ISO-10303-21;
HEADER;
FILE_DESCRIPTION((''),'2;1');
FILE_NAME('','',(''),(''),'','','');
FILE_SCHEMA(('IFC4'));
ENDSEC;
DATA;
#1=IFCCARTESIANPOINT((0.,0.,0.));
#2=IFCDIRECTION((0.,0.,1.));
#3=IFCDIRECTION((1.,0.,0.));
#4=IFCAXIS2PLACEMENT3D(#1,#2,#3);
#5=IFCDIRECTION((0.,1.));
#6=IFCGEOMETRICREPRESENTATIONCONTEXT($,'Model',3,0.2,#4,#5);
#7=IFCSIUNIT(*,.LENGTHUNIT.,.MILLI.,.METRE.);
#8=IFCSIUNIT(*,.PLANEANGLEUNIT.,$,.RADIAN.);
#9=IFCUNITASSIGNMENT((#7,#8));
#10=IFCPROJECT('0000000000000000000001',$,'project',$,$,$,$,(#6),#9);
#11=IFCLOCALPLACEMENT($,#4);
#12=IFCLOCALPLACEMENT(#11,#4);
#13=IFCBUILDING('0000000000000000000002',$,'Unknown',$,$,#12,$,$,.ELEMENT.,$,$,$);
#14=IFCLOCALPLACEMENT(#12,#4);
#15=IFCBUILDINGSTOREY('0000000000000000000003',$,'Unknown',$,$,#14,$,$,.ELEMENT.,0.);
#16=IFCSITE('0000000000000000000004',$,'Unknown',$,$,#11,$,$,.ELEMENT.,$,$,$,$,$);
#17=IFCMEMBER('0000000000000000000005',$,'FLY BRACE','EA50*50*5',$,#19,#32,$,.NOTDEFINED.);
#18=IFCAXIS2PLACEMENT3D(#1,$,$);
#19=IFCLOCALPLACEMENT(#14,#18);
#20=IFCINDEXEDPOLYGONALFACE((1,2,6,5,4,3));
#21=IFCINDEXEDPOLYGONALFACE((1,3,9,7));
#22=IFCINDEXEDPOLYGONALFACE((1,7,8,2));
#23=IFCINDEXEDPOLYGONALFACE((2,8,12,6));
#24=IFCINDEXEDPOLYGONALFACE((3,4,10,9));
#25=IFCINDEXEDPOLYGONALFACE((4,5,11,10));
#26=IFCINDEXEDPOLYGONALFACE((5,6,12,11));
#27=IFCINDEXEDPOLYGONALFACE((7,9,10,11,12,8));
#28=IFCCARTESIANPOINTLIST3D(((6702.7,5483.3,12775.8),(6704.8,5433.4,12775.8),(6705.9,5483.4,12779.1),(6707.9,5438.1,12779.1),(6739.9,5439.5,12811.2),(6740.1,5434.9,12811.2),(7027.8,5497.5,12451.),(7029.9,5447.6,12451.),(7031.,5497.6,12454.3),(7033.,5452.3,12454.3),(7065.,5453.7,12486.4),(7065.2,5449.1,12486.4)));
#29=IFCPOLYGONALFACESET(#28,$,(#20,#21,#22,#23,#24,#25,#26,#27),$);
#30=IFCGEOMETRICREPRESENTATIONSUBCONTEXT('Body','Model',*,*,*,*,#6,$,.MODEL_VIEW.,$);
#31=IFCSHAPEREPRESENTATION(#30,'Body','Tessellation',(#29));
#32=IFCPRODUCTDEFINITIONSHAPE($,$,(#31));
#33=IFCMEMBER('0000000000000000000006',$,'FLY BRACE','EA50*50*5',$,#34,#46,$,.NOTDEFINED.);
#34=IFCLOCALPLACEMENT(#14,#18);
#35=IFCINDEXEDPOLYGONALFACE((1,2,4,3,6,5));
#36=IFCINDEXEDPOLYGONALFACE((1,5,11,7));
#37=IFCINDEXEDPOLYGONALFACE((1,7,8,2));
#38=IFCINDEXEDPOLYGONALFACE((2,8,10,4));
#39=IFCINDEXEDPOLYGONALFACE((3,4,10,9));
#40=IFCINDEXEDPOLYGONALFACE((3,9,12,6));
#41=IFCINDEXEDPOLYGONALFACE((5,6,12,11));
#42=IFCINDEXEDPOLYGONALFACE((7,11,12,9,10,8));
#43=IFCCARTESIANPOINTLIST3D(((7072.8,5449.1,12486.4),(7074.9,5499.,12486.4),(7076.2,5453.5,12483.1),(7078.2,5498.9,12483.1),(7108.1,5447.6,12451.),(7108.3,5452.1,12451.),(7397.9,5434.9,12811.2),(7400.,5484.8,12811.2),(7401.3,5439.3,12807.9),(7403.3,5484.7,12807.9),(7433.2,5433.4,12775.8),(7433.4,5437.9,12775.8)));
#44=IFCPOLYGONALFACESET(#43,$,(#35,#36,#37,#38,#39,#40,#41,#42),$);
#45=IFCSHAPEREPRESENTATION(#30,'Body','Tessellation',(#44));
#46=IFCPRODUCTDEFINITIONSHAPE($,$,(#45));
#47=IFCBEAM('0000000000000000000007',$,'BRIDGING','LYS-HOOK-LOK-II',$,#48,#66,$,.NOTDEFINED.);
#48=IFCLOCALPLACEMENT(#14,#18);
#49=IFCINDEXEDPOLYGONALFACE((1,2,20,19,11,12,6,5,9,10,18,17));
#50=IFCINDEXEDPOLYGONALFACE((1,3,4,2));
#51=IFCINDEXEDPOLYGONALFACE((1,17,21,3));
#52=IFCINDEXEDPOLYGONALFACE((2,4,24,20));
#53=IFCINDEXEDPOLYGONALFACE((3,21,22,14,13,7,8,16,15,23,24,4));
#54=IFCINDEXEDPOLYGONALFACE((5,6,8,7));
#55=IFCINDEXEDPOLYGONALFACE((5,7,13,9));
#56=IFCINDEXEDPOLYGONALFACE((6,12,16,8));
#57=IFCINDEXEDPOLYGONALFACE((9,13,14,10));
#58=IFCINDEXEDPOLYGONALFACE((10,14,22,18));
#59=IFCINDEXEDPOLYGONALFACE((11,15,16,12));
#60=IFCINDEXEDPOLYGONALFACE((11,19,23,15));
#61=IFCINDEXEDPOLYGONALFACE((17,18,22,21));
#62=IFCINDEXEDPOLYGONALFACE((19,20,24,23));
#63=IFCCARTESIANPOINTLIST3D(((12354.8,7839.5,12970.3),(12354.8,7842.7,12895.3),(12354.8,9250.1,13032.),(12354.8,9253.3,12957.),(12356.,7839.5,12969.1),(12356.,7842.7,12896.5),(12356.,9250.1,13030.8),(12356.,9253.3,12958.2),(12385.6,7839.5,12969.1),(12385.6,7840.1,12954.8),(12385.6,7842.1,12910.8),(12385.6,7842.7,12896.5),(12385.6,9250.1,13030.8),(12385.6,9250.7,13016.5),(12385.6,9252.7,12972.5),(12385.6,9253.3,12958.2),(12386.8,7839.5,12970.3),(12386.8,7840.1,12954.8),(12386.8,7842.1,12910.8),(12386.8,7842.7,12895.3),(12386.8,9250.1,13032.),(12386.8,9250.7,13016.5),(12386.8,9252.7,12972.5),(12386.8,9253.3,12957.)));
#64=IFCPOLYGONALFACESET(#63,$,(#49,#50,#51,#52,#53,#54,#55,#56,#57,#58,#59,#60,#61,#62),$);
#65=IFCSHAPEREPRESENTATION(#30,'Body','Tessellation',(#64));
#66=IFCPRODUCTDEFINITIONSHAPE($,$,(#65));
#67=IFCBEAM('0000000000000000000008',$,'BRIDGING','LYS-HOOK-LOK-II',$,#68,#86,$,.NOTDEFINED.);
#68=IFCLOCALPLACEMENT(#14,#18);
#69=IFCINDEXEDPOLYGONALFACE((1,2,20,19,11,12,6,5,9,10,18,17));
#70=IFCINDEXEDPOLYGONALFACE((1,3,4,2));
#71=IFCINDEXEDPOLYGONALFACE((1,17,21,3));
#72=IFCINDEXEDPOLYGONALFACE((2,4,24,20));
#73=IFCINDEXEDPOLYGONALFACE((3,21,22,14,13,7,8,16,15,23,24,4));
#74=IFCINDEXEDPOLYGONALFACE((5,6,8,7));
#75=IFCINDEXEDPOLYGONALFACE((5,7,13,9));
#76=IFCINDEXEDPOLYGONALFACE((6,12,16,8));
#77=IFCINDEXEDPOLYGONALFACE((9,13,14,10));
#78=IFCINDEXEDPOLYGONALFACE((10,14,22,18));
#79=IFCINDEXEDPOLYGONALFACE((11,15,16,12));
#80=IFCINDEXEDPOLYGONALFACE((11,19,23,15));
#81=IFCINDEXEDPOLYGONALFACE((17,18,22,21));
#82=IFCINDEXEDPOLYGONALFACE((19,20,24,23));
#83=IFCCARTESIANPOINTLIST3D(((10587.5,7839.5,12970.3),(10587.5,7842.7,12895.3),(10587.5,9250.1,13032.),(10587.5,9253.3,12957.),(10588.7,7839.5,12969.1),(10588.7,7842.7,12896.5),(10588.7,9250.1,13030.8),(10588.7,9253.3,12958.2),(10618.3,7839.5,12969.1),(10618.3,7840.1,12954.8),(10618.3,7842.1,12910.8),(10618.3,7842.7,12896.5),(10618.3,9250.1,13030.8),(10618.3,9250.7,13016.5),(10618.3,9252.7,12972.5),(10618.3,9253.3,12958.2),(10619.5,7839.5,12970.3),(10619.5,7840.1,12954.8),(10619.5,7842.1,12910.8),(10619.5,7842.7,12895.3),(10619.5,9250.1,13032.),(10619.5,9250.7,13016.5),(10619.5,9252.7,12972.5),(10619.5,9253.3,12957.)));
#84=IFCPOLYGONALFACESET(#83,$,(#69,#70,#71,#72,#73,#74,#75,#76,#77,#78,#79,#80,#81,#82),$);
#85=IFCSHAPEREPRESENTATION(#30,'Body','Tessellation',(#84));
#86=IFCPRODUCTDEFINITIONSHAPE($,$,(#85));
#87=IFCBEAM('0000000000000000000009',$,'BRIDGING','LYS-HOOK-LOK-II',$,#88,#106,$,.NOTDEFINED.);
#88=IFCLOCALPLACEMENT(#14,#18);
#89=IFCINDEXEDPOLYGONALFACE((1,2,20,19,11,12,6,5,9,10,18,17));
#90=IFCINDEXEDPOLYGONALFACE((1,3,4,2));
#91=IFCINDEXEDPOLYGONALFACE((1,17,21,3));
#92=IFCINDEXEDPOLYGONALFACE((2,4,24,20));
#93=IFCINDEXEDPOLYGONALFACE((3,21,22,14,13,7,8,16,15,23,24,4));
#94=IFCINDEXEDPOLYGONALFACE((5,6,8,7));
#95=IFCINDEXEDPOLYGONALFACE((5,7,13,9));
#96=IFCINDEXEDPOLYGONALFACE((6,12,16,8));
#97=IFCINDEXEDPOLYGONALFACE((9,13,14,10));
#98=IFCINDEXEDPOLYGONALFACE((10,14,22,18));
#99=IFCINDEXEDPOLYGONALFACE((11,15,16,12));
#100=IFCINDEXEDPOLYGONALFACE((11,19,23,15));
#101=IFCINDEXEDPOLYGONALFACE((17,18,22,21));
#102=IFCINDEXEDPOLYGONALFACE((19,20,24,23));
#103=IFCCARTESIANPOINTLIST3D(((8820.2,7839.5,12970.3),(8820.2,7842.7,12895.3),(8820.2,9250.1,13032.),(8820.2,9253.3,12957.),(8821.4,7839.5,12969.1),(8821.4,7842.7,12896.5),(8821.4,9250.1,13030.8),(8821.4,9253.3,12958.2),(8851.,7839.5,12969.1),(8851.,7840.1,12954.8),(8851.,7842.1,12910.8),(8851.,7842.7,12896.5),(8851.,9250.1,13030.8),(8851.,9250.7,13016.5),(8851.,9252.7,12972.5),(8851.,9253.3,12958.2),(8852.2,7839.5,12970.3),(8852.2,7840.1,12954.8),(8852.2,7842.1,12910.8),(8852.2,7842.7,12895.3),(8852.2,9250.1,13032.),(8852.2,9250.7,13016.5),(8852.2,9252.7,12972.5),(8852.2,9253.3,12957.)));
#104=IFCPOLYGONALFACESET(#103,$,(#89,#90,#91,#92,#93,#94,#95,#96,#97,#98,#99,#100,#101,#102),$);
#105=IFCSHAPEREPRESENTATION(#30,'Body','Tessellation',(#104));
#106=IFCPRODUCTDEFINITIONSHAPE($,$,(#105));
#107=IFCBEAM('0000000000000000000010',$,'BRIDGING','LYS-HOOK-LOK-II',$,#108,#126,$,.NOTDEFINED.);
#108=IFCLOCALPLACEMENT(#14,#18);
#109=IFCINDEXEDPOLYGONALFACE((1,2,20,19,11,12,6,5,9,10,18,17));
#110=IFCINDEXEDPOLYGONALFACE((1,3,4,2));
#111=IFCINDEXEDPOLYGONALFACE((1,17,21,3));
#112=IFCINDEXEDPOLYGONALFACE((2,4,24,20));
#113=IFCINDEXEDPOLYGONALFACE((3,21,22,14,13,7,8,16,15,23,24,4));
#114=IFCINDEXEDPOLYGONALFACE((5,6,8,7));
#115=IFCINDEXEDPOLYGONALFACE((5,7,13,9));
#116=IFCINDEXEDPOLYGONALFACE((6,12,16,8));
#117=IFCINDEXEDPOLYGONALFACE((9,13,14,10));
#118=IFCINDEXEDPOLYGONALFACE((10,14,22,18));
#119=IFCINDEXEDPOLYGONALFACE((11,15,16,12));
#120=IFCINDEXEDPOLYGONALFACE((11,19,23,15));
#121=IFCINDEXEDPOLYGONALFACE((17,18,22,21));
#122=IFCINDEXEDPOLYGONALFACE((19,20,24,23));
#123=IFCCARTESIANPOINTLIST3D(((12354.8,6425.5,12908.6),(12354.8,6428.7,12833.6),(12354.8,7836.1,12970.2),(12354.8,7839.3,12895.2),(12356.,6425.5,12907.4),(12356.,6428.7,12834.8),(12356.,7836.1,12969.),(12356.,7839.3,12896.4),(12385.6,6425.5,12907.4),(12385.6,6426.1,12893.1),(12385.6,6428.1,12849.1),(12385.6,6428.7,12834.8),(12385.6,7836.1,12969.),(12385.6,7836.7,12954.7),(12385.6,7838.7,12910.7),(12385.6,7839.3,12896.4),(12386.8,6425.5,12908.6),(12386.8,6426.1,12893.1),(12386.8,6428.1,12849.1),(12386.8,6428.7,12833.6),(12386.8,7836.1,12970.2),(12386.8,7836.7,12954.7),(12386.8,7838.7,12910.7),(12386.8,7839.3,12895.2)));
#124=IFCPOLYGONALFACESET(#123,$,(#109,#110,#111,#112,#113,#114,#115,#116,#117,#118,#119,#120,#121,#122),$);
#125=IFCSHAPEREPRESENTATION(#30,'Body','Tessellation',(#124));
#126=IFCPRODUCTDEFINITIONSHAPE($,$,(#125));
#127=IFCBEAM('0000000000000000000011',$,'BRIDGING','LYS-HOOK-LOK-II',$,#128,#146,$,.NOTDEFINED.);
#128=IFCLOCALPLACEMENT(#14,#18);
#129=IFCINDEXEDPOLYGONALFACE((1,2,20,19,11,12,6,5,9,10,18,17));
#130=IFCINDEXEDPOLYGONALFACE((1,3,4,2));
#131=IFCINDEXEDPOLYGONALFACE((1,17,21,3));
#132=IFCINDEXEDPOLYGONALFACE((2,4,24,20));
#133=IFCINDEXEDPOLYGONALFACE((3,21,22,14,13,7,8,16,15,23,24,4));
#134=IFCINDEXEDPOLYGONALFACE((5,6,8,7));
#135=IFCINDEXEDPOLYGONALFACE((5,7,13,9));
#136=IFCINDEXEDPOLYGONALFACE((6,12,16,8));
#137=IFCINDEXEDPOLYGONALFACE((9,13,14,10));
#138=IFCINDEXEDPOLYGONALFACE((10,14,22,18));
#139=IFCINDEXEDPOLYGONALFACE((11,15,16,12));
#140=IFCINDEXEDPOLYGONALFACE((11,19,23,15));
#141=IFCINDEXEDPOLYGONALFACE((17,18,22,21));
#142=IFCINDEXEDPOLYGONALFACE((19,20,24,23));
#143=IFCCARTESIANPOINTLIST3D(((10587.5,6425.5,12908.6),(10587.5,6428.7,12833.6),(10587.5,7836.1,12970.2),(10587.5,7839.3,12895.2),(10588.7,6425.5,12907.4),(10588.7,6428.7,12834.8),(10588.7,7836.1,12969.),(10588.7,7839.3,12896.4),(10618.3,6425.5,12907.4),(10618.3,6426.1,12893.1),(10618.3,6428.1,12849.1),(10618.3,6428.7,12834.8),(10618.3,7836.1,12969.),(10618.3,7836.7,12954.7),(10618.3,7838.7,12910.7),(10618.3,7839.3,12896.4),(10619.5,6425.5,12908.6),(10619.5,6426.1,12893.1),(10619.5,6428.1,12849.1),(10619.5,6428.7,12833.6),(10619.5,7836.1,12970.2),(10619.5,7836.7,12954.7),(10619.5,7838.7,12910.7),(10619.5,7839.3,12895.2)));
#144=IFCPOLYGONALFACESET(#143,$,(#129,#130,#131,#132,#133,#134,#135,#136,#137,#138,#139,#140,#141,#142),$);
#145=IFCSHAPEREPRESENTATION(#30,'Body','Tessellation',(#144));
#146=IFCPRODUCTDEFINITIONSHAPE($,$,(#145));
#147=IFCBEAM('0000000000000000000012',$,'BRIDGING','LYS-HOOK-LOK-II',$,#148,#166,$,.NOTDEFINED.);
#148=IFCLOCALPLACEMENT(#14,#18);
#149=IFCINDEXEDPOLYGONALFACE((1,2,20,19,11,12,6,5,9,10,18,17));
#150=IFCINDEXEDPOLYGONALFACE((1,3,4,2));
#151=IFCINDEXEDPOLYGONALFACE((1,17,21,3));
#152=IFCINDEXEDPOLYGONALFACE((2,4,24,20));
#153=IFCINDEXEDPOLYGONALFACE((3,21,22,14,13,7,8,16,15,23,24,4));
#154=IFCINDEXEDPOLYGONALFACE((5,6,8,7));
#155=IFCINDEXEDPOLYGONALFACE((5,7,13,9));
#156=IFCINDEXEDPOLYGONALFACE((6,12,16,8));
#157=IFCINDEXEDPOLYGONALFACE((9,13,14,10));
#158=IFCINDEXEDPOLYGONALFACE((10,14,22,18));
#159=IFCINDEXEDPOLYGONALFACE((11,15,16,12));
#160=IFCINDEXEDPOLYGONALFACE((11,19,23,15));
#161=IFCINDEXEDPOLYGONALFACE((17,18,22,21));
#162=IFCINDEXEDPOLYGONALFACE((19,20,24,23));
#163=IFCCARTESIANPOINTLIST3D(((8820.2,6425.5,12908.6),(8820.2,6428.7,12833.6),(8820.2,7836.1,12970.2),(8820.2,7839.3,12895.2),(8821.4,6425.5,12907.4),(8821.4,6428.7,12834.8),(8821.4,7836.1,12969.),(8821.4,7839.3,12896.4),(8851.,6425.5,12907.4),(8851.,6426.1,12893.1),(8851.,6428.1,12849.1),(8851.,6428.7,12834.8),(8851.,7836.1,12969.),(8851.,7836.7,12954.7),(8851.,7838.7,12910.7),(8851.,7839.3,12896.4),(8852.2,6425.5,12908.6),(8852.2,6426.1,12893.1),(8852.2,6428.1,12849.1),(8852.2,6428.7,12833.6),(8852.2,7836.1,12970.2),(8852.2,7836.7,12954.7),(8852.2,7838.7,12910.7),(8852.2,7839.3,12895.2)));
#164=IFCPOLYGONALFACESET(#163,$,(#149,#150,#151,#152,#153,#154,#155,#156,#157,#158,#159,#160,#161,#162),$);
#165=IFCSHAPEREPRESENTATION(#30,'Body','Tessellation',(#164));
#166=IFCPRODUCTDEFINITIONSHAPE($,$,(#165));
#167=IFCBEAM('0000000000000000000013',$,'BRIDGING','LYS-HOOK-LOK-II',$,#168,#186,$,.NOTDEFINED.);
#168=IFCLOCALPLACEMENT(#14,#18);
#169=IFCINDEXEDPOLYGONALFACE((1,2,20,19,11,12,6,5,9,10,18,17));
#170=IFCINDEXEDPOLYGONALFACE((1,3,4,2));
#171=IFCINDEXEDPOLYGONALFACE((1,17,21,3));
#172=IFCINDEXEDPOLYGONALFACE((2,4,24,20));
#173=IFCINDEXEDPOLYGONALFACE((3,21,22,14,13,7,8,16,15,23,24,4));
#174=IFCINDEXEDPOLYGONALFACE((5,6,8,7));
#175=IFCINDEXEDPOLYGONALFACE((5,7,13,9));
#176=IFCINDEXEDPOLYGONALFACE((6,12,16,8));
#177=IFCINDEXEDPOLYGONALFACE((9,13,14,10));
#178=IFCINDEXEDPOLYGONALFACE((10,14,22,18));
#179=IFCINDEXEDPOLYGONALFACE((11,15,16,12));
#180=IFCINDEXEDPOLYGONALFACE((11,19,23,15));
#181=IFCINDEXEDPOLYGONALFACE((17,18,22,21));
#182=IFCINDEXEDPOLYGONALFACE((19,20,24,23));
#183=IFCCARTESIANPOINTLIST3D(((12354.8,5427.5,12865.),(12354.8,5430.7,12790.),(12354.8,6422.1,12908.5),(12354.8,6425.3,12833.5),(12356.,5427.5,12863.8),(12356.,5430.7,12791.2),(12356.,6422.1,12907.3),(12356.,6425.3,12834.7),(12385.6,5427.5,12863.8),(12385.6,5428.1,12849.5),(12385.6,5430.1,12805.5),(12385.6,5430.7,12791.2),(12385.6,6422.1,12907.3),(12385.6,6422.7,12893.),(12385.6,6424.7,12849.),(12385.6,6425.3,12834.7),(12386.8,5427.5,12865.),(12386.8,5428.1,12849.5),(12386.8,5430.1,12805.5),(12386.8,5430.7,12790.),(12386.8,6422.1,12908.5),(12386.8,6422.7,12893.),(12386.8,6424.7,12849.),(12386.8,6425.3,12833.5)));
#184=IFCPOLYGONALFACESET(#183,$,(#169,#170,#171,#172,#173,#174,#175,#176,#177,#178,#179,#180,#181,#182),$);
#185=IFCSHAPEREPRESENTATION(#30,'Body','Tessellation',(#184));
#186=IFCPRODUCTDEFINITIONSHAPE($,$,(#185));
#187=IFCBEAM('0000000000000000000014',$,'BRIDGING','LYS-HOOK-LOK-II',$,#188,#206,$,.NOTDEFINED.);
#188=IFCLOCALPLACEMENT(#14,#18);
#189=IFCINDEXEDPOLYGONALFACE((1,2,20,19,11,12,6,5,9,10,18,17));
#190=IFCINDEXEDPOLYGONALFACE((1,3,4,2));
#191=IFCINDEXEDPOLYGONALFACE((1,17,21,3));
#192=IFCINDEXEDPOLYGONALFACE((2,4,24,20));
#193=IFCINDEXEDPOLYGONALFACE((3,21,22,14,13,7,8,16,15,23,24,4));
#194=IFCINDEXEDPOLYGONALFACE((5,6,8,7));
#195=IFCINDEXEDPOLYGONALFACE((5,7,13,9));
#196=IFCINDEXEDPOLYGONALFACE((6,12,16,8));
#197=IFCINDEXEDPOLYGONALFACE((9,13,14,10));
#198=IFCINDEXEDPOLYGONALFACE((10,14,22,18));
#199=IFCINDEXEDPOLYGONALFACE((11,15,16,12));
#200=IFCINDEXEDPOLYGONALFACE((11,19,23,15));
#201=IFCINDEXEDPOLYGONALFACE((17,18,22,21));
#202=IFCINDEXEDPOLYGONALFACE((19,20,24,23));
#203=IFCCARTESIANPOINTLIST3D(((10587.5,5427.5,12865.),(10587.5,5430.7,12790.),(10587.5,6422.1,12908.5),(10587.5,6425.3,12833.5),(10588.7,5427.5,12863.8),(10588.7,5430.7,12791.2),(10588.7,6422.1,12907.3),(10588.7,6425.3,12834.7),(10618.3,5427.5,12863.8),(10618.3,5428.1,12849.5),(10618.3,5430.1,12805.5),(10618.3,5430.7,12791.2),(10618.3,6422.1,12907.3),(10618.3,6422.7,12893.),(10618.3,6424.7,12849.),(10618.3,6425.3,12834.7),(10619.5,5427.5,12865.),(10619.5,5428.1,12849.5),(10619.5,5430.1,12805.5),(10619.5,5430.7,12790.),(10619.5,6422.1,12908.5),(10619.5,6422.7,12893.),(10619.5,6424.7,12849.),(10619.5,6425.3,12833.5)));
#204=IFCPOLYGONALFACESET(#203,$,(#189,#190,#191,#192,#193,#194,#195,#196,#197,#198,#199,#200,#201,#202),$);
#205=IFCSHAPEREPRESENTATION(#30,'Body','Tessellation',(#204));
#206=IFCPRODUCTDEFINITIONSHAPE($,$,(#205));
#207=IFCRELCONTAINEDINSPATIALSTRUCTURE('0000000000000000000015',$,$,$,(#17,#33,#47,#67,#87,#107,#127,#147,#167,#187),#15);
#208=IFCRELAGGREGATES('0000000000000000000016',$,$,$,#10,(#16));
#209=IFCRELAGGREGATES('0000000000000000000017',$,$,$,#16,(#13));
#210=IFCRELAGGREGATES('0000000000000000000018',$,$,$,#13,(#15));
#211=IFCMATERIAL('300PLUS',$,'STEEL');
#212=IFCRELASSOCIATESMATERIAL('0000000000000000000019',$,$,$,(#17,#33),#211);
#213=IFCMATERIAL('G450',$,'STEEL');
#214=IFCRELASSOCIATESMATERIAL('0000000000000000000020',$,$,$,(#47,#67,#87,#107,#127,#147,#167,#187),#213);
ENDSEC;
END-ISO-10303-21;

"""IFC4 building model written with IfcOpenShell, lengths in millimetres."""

from ifc_helpers import new_model, si_unit, direction, frame, origin_with_axes, place, context, subcontext, project, spatial, line, indexed_curve, outline, extrude, material, element, save


model = new_model("IFC4")

# Units and contexts
model_context = context("Model", 3, precision=0.2, world=origin_with_axes(), true_north=direction((0.0, 1.0)))
body_context = subcontext(model_context, "Body", "Model", "MODEL_VIEW")
ifc_project = project(units=[si_unit("LENGTHUNIT", "METRE", prefix="MILLI"), si_unit("PLANEANGLEUNIT", "RADIAN")], contexts=[model_context])

# Site, building, storey
site_placement = place(None, origin_with_axes())
site = spatial("IfcSite", under=ifc_project, at=site_placement, Name="Unknown", CompositionType="ELEMENT")
building_placement = place(site_placement, origin_with_axes())
building = spatial("IfcBuilding", under=site, at=building_placement, Name="Unknown", CompositionType="ELEMENT")
storey_placement = place(building_placement, origin_with_axes())
storey = spatial("IfcBuildingStorey", under=building, at=storey_placement, Name="Unknown", CompositionType="ELEMENT", Elevation=0.0)

# Members
ifc_material_1 = material(Name="300PLUS", Category="STEEL")
for number, where, z_axis, x_axis, name in (
    (1, (7046.5, 5473.3, 12468.7), (-0.043637, 0.999047, 0.0), (-0.707096, -0.030885, 0.706443), "FLY BRACE"),
    (2, (7091.5, 5473.3, 12468.7), (0.043637, 0.999047, 0.0), (0.707096, -0.030885, 0.706443), "FLY BRACE"),
):
    element("IfcMember", number, at=place(storey_placement, frame(where, z_axis=z_axis, x_axis=x_axis)), inside=storey, material=ifc_material_1, Name=name, Description="EA50*50*5", PredefinedType="NOTDEFINED", context=body_context, shape_type="SolidModel", body=[
        extrude(outline(indexed_curve([(-25.0, -25.0), (25.0, -25.0), (25.0, -20.4), (-20.4, -20.4), (-20.4, 25.0), (-25.0, 25.0)], segments=[line(1, 2, 3, 4, 5, 6, 1)])), frame((0.0, 0.0, 0.0), z_axis=(-1.0, 0.0, 0.0), x_axis=(0.0, 0.0, 1.0)), (0.0, 0.0, -1.0), 459.8),
    ])

# Beams
ifc_material_2 = material(Name="G450", Category="STEEL")
for number, where, z_axis, x_axis, name in (
    (3, (12370.8, 7841.1, 12932.8), (1.0, 0.0, 0.0), (0.0, 0.999045, 0.043698), "BRIDGING"),
    (4, (10603.5, 7841.1, 12932.8), (1.0, 0.0, 0.0), (0.0, 0.999045, 0.043698), "BRIDGING"),
    (5, (8836.2, 7841.1, 12932.8), (1.0, 0.0, 0.0), (0.0, 0.999045, 0.043698), "BRIDGING"),
):
    element("IfcBeam", number, at=place(storey_placement, frame(where, z_axis=z_axis, x_axis=x_axis)), inside=storey, material=ifc_material_2, Name=name, Description="LYS-HOOK-LOK-II", PredefinedType="NOTDEFINED", context=body_context, shape_type="SolidModel", body=[
        extrude(outline(indexed_curve([(16.0, -37.5), (16.0, -22.0), (14.8, -22.0), (14.8, -36.3), (-14.8, -36.3), (-14.8, 36.3), (14.8, 36.3), (14.8, 22.0), (16.0, 22.0), (16.0, 37.5), (-16.0, 37.5), (-16.0, -37.5)], segments=[line(1, 2, 3, 4, 5, 6, 7, 8, 9, 10, 11, 12, 1)])), frame((0.0, 0.0, 0.0), z_axis=(-1.0, 0.0, 0.0), x_axis=(0.0, 0.0, 1.0)), (0.0, 0.0, -1.0), 1411.9),
    ])
for number, where, z_axis, x_axis, name in (
    (6, (12370.8, 6427.1, 12871.1), (1.0, 0.0, 0.0), (0.0, 0.999048, 0.043628), "BRIDGING"),
    (7, (10603.5, 6427.1, 12871.1), (1.0, 0.0, 0.0), (0.0, 0.999048, 0.043628), "BRIDGING"),
    (8, (8836.2, 6427.1, 12871.1), (1.0, 0.0, 0.0), (0.0, 0.999048, 0.043628), "BRIDGING"),
):
    element("IfcBeam", number, at=place(storey_placement, frame(where, z_axis=z_axis, x_axis=x_axis)), inside=storey, material=ifc_material_2, Name=name, Description="LYS-HOOK-LOK-II", PredefinedType="NOTDEFINED", context=body_context, shape_type="SolidModel", body=[
        extrude(outline(indexed_curve([(16.0, -37.5), (16.0, -22.0), (14.8, -22.0), (14.8, -36.3), (-14.8, -36.3), (-14.8, 36.3), (14.8, 36.3), (14.8, 22.0), (16.0, 22.0), (16.0, 37.5), (-16.0, 37.5), (-16.0, -37.5)], segments=[line(1, 2, 3, 4, 5, 6, 7, 8, 9, 10, 11, 12, 1)])), frame((0.0, 0.0, 0.0), z_axis=(-1.0, 0.0, 0.0), x_axis=(0.0, 0.0, 1.0)), (0.0, 0.0, -1.0), 1411.9),
    ])
for number, where, z_axis, x_axis, name in (
    (9, (12370.8, 5429.1, 12827.5), (1.0, 0.0, 0.0), (0.0, 0.999045, 0.043694), "BRIDGING"),
    (10, (10603.5, 5429.1, 12827.5), (1.0, 0.0, 0.0), (0.0, 0.999045, 0.043694), "BRIDGING"),
):
    element("IfcBeam", number, at=place(storey_placement, frame(where, z_axis=z_axis, x_axis=x_axis)), inside=storey, material=ifc_material_2, Name=name, Description="LYS-HOOK-LOK-II", PredefinedType="NOTDEFINED", context=body_context, shape_type="SolidModel", body=[
        extrude(outline(indexed_curve([(16.0, -37.5), (16.0, -22.0), (14.8, -22.0), (14.8, -36.3), (-14.8, -36.3), (-14.8, 36.3), (14.8, 36.3), (14.8, 22.0), (16.0, 22.0), (16.0, 37.5), (-16.0, 37.5), (-16.0, -37.5)], segments=[line(1, 2, 3, 4, 5, 6, 7, 8, 9, 10, 11, 12, 1)])), frame((0.0, 0.0, 0.0), z_axis=(-1.0, 0.0, 0.0), x_axis=(0.0, 0.0, 1.0)), (0.0, 0.0, -1.0), 995.6),
    ])

save(model, "model.ifc")
